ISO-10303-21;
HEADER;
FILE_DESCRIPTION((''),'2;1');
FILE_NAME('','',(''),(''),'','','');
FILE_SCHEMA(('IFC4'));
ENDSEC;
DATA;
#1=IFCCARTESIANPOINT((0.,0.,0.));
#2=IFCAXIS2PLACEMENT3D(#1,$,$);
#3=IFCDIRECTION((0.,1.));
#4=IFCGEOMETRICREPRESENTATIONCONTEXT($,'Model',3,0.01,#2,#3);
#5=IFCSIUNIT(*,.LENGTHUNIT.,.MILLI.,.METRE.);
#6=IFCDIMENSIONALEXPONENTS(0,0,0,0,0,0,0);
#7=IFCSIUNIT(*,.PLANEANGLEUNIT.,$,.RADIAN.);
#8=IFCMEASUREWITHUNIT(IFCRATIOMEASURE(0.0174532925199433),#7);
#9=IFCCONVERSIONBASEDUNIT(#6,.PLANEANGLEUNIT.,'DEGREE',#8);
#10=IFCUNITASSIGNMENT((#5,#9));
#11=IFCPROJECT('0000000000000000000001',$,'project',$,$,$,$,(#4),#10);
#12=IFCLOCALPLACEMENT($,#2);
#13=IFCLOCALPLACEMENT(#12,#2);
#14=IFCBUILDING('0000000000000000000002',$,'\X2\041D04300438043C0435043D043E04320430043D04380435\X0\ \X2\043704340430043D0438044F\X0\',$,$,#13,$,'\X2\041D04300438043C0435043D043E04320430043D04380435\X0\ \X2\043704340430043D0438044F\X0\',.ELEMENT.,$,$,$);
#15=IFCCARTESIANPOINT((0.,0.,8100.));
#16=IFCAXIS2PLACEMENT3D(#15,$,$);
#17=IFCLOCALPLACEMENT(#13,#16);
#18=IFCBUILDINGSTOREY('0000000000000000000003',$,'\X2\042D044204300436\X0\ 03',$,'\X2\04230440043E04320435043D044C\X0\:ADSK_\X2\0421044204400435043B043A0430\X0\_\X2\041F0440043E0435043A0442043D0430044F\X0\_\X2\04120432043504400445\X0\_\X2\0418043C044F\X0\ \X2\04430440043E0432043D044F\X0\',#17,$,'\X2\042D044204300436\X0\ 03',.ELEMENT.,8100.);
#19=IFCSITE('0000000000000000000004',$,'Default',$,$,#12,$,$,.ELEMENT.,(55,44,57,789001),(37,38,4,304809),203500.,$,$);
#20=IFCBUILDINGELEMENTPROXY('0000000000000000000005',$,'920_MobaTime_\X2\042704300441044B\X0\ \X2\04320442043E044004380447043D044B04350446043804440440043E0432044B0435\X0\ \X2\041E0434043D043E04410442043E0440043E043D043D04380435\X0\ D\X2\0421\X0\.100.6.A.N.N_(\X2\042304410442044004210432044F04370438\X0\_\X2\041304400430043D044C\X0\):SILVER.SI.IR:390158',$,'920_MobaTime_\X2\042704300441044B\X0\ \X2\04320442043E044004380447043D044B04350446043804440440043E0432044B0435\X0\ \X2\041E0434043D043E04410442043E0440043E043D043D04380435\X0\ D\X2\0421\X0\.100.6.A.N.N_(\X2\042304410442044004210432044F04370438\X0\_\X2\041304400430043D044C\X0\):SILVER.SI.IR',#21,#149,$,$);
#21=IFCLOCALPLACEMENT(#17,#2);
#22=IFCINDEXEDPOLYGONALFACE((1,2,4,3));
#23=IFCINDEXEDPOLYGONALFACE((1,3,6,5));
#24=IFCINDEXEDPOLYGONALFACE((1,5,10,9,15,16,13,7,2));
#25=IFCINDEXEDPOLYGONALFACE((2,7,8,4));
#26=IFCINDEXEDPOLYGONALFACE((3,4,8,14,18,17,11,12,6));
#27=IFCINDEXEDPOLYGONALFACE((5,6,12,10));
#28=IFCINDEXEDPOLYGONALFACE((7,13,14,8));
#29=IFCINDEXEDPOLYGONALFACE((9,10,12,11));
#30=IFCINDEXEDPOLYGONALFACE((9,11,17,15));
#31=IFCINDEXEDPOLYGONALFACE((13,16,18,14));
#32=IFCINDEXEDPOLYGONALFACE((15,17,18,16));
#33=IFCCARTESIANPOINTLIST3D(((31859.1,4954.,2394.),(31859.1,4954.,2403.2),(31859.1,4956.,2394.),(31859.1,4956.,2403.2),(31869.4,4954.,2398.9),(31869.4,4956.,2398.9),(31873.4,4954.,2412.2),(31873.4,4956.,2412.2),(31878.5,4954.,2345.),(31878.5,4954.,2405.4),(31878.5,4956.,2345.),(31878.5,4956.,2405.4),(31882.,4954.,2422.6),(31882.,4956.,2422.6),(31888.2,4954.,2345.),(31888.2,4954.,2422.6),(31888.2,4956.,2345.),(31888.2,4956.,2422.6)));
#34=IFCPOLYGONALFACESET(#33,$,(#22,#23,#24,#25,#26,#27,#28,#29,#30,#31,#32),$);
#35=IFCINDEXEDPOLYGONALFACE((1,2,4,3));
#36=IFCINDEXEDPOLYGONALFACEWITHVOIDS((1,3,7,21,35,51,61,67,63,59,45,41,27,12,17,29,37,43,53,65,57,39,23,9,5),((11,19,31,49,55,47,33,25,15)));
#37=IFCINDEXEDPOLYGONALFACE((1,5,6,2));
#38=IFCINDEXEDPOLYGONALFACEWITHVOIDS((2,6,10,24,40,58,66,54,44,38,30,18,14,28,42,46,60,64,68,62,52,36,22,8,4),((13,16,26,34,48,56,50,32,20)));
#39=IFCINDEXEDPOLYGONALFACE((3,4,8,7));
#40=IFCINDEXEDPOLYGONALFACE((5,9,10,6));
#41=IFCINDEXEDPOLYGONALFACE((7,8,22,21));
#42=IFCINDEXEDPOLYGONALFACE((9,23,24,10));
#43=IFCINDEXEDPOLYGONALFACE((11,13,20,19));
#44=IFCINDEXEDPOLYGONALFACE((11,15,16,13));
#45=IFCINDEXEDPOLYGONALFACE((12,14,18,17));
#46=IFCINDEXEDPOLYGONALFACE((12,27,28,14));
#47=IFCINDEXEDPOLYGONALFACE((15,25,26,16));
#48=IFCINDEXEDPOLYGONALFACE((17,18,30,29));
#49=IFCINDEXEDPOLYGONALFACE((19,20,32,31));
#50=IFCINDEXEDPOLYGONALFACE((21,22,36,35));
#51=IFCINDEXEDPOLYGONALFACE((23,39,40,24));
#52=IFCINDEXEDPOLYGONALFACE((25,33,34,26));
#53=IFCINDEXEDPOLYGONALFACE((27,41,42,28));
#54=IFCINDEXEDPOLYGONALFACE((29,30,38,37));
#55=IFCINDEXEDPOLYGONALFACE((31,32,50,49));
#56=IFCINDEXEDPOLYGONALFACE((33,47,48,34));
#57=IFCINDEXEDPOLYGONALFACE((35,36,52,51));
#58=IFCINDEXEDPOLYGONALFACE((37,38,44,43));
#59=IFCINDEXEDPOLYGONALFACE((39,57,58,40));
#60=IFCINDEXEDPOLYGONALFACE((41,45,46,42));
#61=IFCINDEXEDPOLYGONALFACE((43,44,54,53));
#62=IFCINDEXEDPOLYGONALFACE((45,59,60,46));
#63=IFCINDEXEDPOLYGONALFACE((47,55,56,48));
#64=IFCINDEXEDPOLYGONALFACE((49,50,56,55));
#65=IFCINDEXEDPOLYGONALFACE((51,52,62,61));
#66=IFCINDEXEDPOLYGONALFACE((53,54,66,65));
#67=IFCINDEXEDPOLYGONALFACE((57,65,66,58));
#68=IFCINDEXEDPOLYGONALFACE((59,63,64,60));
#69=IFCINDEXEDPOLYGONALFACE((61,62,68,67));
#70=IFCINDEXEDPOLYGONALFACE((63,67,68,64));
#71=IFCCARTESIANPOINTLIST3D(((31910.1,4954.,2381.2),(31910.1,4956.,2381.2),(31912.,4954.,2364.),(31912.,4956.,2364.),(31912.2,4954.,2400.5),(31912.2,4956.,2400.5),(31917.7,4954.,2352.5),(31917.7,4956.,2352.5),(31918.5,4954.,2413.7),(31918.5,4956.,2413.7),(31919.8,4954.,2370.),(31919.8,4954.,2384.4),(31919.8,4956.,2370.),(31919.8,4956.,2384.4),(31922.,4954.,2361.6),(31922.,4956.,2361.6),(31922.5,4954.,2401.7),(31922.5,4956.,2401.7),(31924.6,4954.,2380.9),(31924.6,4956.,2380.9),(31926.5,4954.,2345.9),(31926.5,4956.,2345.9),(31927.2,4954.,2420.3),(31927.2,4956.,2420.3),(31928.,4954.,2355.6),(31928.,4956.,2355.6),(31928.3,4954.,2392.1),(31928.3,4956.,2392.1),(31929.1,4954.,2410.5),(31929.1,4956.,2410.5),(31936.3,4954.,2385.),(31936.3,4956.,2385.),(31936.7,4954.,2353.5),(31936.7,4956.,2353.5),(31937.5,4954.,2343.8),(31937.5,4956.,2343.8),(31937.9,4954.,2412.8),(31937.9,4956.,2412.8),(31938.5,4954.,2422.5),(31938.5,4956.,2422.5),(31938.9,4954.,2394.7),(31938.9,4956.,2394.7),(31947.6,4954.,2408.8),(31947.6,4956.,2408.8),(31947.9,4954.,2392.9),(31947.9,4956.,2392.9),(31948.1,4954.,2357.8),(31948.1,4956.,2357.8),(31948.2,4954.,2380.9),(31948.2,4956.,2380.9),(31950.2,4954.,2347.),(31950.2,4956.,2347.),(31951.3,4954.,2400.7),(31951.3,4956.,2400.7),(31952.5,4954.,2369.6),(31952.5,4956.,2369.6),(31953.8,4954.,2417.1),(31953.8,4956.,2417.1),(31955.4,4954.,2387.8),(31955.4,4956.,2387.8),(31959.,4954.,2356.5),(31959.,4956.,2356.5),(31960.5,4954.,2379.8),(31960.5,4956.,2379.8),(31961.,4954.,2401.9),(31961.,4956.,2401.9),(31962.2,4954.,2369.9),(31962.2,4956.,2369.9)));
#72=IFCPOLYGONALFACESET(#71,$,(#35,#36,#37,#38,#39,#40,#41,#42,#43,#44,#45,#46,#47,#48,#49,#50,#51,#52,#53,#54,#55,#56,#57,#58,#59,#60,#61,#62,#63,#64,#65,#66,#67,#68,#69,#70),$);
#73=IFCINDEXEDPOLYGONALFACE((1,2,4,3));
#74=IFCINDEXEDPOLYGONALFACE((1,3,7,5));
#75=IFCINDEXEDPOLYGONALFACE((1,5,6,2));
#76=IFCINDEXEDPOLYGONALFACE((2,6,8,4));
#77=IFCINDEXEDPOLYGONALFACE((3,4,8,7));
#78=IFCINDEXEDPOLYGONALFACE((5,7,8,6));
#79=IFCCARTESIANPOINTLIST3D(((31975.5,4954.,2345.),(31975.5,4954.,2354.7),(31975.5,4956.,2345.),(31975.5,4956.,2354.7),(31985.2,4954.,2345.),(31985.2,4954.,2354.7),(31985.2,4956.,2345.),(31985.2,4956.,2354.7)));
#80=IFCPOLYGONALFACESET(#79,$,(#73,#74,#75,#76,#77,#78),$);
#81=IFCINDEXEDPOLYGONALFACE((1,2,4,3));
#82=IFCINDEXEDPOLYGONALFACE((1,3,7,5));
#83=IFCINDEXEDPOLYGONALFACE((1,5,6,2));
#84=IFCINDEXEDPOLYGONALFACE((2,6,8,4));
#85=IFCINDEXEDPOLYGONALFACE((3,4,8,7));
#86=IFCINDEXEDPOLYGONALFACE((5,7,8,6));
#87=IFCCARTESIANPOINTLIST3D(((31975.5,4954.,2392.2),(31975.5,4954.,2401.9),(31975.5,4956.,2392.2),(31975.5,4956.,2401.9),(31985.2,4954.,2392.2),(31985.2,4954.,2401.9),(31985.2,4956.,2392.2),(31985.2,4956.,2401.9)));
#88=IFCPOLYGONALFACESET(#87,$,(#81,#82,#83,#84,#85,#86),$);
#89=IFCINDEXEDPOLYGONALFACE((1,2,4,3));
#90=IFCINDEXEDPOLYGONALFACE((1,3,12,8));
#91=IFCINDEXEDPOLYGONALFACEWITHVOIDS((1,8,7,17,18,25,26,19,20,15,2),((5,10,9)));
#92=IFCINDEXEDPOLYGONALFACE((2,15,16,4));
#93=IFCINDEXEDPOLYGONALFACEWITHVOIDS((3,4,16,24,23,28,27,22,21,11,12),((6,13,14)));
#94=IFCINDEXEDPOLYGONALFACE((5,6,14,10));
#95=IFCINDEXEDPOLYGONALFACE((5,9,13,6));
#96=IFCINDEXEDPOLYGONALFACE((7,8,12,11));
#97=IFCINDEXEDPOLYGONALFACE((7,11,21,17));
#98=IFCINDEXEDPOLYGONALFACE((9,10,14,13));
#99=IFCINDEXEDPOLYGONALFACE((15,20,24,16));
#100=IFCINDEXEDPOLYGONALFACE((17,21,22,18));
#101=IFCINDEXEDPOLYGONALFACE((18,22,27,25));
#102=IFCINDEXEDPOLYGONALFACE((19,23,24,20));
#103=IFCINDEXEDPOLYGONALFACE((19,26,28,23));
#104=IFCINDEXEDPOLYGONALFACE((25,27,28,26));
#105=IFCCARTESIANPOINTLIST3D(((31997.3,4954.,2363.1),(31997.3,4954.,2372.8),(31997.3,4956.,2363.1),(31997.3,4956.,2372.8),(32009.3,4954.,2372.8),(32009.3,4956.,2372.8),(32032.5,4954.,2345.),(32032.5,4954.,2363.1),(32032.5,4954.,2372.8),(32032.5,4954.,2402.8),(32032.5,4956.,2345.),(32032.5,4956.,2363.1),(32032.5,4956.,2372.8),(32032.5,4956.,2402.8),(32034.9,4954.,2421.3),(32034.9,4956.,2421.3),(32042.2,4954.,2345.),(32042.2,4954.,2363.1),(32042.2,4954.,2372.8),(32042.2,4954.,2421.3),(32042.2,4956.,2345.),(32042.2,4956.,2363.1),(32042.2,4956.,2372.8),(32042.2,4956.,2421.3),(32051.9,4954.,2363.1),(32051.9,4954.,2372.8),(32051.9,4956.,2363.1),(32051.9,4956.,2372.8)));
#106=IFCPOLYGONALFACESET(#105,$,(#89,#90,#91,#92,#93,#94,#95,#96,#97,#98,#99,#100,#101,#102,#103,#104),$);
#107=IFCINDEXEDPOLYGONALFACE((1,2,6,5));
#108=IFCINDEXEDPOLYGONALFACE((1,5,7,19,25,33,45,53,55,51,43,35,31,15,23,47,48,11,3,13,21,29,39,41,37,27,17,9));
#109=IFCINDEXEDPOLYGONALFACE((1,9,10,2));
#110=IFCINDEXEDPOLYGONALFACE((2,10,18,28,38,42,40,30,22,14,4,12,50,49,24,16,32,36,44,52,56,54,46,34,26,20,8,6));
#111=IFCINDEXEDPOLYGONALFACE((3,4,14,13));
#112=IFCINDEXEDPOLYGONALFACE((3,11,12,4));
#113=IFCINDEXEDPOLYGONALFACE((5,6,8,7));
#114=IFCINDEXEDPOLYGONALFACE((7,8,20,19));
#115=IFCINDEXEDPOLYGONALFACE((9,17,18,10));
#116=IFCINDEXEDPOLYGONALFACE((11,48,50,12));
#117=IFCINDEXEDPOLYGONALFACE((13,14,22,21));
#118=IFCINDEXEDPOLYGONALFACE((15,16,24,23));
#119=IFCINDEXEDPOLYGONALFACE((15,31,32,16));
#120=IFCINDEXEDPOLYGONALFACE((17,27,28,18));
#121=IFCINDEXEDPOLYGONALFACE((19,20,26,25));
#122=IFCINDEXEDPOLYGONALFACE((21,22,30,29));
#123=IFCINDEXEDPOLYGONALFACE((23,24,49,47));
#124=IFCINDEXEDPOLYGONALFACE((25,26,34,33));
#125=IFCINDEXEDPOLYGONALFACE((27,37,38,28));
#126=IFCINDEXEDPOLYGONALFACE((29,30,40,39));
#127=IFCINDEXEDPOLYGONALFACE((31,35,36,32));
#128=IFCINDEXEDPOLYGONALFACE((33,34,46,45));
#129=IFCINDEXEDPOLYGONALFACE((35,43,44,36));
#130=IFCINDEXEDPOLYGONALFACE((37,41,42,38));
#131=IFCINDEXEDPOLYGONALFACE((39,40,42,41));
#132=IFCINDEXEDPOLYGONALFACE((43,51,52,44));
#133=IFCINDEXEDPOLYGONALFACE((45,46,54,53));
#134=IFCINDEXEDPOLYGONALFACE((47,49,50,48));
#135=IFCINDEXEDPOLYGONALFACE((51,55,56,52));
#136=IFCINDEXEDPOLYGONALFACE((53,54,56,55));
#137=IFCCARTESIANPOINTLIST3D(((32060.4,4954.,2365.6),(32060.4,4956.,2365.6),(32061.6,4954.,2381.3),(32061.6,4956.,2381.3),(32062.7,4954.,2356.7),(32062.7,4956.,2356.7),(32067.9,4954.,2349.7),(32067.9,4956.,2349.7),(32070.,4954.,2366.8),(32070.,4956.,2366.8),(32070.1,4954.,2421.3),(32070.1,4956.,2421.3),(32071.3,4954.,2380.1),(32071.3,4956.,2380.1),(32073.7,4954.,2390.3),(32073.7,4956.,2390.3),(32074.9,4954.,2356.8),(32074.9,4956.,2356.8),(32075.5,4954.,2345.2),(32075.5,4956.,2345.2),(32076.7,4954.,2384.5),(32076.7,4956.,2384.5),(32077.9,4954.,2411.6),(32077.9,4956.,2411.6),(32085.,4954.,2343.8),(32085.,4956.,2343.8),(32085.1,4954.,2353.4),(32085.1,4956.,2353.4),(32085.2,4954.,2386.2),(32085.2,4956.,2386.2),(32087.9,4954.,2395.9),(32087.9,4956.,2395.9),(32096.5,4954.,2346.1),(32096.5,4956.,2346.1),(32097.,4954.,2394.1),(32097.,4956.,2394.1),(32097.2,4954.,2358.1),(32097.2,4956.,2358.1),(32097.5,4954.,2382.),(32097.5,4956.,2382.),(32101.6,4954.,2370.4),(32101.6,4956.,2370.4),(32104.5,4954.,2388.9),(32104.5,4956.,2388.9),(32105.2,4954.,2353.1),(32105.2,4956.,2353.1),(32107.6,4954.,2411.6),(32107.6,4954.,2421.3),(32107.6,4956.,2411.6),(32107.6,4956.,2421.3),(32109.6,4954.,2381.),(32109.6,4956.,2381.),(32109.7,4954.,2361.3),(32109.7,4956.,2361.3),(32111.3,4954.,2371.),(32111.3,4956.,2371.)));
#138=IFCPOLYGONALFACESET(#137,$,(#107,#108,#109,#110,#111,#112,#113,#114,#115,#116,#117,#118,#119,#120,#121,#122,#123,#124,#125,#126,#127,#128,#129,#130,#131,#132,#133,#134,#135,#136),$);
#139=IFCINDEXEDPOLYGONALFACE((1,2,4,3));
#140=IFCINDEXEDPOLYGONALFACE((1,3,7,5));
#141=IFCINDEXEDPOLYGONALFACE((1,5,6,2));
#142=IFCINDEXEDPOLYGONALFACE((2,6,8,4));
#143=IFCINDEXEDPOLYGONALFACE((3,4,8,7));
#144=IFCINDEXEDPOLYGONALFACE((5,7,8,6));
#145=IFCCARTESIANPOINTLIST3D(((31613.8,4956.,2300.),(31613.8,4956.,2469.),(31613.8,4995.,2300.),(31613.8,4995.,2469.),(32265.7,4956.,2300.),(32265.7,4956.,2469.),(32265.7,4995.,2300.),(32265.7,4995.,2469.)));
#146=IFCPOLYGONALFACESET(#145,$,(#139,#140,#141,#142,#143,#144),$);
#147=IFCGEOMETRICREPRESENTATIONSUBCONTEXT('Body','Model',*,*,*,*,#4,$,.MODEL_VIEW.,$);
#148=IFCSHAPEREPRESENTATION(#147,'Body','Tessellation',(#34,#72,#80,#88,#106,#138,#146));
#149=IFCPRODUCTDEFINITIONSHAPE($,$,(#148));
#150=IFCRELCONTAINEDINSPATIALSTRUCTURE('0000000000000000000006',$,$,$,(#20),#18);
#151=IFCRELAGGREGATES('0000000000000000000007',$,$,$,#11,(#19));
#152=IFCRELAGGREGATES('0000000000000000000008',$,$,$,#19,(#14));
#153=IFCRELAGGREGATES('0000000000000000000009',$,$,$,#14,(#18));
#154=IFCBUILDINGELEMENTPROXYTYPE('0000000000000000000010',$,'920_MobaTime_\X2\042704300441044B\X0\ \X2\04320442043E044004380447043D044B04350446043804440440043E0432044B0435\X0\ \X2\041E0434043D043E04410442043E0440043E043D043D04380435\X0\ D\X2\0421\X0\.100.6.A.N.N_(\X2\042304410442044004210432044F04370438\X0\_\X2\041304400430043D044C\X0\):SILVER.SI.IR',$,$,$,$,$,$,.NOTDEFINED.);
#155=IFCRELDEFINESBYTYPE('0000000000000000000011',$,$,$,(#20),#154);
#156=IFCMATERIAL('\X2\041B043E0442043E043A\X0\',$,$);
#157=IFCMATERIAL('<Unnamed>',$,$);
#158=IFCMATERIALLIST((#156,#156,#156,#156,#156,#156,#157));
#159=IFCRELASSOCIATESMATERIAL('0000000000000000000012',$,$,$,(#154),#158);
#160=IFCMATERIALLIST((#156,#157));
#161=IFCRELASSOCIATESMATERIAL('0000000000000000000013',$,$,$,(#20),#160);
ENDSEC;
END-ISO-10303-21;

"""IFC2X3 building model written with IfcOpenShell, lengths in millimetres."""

from ifc_helpers import new_model, entity, si_unit, converted_unit, direction, frame, origin, origin_2d_with_axis, place, context, subcontext, project, spatial, polyline, rectangle, outline, extrude, source, transform, mapped, material, material_list, type_object, type_shapes, element, save


model = new_model("IFC2X3")

# Units and contexts
model_context = context("Model", 3, precision=0.01, world=origin(), true_north=direction((0.0, 1.0)))
body_context = subcontext(model_context, "Body", "Model", "MODEL_VIEW")
ifc_project = project(units=[si_unit("LENGTHUNIT", "METRE", prefix="MILLI"), converted_unit("PLANEANGLEUNIT", "DEGREE", entity("IfcRatioMeasure", 0.0174532925199433), si_unit("PLANEANGLEUNIT", "RADIAN"), dimensions=[0, 0, 0, 0, 0, 0, 0])], contexts=[model_context])

# Site, building, storey
site_placement = place(None, origin())
site = spatial("IfcSite", under=ifc_project, at=site_placement, Name="Default", CompositionType="ELEMENT", RefLatitude=(55, 44, 57, 789001), RefLongitude=(37, 38, 4, 304809), RefElevation=203500.0)
building_placement = place(site_placement, origin())
building = spatial("IfcBuilding", under=site, at=building_placement, Name="Наименование здания", LongName="Наименование здания", CompositionType="ELEMENT")
storey_placement = place(building_placement, frame((0.0, 0.0, 8100.0)))
storey = spatial("IfcBuildingStorey", under=building, at=storey_placement, Name="Этаж 03", ObjectType="Уровень:ADSK_Стрелка_Проектная_Вверх_Имя уровня", LongName="Этаж 03", CompositionType="ELEMENT", Elevation=8100.0)

# Building element proxy
ifc_material_1 = material(Name="Лоток")
ifc_material_2 = material(Name="<Unnamed>")
ifc_material_list_1 = material_list([ifc_material_1, ifc_material_1, ifc_material_1, ifc_material_1, ifc_material_1, ifc_material_1, ifc_material_2])
building_element_proxy_type = type_object("IfcBuildingElementProxyType", Name="920_MobaTime_Часы вторичныецифровые Односторонние DС.100.6.A.N.N_(УстрСвязи_Грань):SILVER.SI.IR", PredefinedType="NOTDEFINED", material=ifc_material_list_1)
shared_shape = source(origin(), body_context, "Body", "SweptSolid", [
    extrude(outline(polyline([(-49.3, -13.1), (28.2, -13.1), (28.2, -6.8), (17.9, 1.8), (8.8, 16.0), (-0.3, 16.0), (4.6, 5.8), (11.1, -3.4), (-49.3, -3.4), (-49.3, -13.1)])), frame((-64.6, 9.8, 39.0), z_axis=(0.0, 0.0, 1.0), x_axis=(0.0, 1.0, 0.0)), (0.0, 0.0, 1.0), 2.0),
    extrude(outline(polyline([(2.2, -27.6), (19.0, -27.6), (30.5, -16.1), (33.3, -4.9), (31.0, 5.8), (21.8, 17.2), (5.2, 27.3), (-11.1, 33.0), (-24.0, 32.7), (-33.6, 27.6), (-40.3, 18.6), (-42.8, 5.7), (-38.0, -6.3), (-27.2, -14.9), (-17.5, -17.7), (-8.2, -16.4), (-0.3, -11.9), (5.1, -4.5), (7.3, 6.2), (4.0, 17.2), (18.4, 7.3), (23.6, -2.4), (22.0, -11.4), (14.2, -18.4), (5.3, -18.3), (2.2, -27.6)]), holes=[polyline([(-9.0, 23.3), (-1.3, 14.3), (-2.5, 2.0), (-11.4, -7.0), (-23.4, -6.0), (-32.2, 2.9), (-31.2, 15.1), (-25.6, 22.1), (-17.5, 24.9), (-9.0, 23.3)])]), frame((-2.7, 3.6, 39.0), z_axis=(0.0, 0.0, 1.0), x_axis=(-0.427649, 0.903945, 0.0)), (0.0, 0.0, 1.0), 2.0),
    extrude(rectangle(XDim=9.7, YDim=9.7, at=origin_2d_with_axis()), frame((40.6, -34.7, 39.0)), (0.0, 0.0, 1.0), 2.0),
    extrude(rectangle(XDim=9.7, YDim=9.7, at=origin_2d_with_axis()), frame((40.6, 12.6, 39.0)), (0.0, 0.0, 1.0), 2.0),
    extrude(outline(polyline([(-0.9, -28.1), (8.8, -28.1), (8.8, -9.9), (18.5, -9.9), (18.5, -0.2), (8.8, -0.2), (8.8, 48.3), (1.5, 48.3), (-36.0, -0.2), (-36.0, -9.9), (-0.9, -9.9), (-0.9, -28.1)]), holes=[polyline([(-0.9, -0.2), (-24.1, -0.2), (-0.9, 29.7), (-0.9, -0.2)])]), frame((93.6, -11.4, 39.0)), (0.0, 0.0, 1.0), 2.0),
    extrude(outline(polyline([(3.3, -28.3), (12.5, -28.3), (20.5, -25.0), (26.8, -18.9), (30.7, -10.0), (31.4, 1.6), (26.9, 11.8), (20.1, 18.4), (11.1, 22.3), (1.0, 23.3), (-7.9, 20.4), (-14.9, 14.5), (-18.9, 6.2), (-17.1, -9.0), (-36.7, 0.5), (-29.1, 29.2), (-38.5, 31.7), (-48.1, -4.6), (-11.6, -23.1), (-8.0, -14.0), (-10.8, -7.6), (-10.2, 1.1), (-3.0, 11.8), (9.2, 12.8), (20.0, 5.5), (21.4, -7.5), (15.5, -16.4), (4.6, -18.6), (3.3, -28.3)])), frame((147.1, -8.5, 39.0), z_axis=(0.0, 0.0, 1.0), x_axis=(0.256974, -0.966418, 0.0)), (0.0, 0.0, 1.0), 2.0),
    extrude(rectangle(XDim=652.0, YDim=169.0, at=origin_2d_with_axis()), frame((0.0, 0.0, 0.0), z_axis=(0.0, 0.0, 1.0), x_axis=(-1.0, 0.0, 0.0)), (0.0, 0.0, 1.0), 39.0),
])
type_shapes(building_element_proxy_type, [shared_shape])
ifc_material_list_2 = material_list([ifc_material_1, ifc_material_2])
for number, where, z_axis, x_axis, name in (
    (1, (31939.8, 4995.0, 2384.5), (0.0, -1.0, 0.0), (1.0, 0.0, 0.0), "920_MobaTime_Часы вторичныецифровые Односторонние DС.100.6.A.N.N_(УстрСвязи_Грань):SILVER.SI.IR:390158"),
):
    element("IfcBuildingElementProxy", number, at=place(storey_placement, frame(where, z_axis=z_axis, x_axis=x_axis)), inside=storey, type_object=building_element_proxy_type, material=ifc_material_list_2, Name=name, ObjectType="920_MobaTime_Часы вторичныецифровые Односторонние DС.100.6.A.N.N_(УстрСвязи_Грань):SILVER.SI.IR", context=body_context, shape_type="MappedRepresentation", body=[
        mapped(shared_shape, transform((0.0, 0.0, 0.0), scale=1.0)),
    ])

save(model, "model.ifc")
